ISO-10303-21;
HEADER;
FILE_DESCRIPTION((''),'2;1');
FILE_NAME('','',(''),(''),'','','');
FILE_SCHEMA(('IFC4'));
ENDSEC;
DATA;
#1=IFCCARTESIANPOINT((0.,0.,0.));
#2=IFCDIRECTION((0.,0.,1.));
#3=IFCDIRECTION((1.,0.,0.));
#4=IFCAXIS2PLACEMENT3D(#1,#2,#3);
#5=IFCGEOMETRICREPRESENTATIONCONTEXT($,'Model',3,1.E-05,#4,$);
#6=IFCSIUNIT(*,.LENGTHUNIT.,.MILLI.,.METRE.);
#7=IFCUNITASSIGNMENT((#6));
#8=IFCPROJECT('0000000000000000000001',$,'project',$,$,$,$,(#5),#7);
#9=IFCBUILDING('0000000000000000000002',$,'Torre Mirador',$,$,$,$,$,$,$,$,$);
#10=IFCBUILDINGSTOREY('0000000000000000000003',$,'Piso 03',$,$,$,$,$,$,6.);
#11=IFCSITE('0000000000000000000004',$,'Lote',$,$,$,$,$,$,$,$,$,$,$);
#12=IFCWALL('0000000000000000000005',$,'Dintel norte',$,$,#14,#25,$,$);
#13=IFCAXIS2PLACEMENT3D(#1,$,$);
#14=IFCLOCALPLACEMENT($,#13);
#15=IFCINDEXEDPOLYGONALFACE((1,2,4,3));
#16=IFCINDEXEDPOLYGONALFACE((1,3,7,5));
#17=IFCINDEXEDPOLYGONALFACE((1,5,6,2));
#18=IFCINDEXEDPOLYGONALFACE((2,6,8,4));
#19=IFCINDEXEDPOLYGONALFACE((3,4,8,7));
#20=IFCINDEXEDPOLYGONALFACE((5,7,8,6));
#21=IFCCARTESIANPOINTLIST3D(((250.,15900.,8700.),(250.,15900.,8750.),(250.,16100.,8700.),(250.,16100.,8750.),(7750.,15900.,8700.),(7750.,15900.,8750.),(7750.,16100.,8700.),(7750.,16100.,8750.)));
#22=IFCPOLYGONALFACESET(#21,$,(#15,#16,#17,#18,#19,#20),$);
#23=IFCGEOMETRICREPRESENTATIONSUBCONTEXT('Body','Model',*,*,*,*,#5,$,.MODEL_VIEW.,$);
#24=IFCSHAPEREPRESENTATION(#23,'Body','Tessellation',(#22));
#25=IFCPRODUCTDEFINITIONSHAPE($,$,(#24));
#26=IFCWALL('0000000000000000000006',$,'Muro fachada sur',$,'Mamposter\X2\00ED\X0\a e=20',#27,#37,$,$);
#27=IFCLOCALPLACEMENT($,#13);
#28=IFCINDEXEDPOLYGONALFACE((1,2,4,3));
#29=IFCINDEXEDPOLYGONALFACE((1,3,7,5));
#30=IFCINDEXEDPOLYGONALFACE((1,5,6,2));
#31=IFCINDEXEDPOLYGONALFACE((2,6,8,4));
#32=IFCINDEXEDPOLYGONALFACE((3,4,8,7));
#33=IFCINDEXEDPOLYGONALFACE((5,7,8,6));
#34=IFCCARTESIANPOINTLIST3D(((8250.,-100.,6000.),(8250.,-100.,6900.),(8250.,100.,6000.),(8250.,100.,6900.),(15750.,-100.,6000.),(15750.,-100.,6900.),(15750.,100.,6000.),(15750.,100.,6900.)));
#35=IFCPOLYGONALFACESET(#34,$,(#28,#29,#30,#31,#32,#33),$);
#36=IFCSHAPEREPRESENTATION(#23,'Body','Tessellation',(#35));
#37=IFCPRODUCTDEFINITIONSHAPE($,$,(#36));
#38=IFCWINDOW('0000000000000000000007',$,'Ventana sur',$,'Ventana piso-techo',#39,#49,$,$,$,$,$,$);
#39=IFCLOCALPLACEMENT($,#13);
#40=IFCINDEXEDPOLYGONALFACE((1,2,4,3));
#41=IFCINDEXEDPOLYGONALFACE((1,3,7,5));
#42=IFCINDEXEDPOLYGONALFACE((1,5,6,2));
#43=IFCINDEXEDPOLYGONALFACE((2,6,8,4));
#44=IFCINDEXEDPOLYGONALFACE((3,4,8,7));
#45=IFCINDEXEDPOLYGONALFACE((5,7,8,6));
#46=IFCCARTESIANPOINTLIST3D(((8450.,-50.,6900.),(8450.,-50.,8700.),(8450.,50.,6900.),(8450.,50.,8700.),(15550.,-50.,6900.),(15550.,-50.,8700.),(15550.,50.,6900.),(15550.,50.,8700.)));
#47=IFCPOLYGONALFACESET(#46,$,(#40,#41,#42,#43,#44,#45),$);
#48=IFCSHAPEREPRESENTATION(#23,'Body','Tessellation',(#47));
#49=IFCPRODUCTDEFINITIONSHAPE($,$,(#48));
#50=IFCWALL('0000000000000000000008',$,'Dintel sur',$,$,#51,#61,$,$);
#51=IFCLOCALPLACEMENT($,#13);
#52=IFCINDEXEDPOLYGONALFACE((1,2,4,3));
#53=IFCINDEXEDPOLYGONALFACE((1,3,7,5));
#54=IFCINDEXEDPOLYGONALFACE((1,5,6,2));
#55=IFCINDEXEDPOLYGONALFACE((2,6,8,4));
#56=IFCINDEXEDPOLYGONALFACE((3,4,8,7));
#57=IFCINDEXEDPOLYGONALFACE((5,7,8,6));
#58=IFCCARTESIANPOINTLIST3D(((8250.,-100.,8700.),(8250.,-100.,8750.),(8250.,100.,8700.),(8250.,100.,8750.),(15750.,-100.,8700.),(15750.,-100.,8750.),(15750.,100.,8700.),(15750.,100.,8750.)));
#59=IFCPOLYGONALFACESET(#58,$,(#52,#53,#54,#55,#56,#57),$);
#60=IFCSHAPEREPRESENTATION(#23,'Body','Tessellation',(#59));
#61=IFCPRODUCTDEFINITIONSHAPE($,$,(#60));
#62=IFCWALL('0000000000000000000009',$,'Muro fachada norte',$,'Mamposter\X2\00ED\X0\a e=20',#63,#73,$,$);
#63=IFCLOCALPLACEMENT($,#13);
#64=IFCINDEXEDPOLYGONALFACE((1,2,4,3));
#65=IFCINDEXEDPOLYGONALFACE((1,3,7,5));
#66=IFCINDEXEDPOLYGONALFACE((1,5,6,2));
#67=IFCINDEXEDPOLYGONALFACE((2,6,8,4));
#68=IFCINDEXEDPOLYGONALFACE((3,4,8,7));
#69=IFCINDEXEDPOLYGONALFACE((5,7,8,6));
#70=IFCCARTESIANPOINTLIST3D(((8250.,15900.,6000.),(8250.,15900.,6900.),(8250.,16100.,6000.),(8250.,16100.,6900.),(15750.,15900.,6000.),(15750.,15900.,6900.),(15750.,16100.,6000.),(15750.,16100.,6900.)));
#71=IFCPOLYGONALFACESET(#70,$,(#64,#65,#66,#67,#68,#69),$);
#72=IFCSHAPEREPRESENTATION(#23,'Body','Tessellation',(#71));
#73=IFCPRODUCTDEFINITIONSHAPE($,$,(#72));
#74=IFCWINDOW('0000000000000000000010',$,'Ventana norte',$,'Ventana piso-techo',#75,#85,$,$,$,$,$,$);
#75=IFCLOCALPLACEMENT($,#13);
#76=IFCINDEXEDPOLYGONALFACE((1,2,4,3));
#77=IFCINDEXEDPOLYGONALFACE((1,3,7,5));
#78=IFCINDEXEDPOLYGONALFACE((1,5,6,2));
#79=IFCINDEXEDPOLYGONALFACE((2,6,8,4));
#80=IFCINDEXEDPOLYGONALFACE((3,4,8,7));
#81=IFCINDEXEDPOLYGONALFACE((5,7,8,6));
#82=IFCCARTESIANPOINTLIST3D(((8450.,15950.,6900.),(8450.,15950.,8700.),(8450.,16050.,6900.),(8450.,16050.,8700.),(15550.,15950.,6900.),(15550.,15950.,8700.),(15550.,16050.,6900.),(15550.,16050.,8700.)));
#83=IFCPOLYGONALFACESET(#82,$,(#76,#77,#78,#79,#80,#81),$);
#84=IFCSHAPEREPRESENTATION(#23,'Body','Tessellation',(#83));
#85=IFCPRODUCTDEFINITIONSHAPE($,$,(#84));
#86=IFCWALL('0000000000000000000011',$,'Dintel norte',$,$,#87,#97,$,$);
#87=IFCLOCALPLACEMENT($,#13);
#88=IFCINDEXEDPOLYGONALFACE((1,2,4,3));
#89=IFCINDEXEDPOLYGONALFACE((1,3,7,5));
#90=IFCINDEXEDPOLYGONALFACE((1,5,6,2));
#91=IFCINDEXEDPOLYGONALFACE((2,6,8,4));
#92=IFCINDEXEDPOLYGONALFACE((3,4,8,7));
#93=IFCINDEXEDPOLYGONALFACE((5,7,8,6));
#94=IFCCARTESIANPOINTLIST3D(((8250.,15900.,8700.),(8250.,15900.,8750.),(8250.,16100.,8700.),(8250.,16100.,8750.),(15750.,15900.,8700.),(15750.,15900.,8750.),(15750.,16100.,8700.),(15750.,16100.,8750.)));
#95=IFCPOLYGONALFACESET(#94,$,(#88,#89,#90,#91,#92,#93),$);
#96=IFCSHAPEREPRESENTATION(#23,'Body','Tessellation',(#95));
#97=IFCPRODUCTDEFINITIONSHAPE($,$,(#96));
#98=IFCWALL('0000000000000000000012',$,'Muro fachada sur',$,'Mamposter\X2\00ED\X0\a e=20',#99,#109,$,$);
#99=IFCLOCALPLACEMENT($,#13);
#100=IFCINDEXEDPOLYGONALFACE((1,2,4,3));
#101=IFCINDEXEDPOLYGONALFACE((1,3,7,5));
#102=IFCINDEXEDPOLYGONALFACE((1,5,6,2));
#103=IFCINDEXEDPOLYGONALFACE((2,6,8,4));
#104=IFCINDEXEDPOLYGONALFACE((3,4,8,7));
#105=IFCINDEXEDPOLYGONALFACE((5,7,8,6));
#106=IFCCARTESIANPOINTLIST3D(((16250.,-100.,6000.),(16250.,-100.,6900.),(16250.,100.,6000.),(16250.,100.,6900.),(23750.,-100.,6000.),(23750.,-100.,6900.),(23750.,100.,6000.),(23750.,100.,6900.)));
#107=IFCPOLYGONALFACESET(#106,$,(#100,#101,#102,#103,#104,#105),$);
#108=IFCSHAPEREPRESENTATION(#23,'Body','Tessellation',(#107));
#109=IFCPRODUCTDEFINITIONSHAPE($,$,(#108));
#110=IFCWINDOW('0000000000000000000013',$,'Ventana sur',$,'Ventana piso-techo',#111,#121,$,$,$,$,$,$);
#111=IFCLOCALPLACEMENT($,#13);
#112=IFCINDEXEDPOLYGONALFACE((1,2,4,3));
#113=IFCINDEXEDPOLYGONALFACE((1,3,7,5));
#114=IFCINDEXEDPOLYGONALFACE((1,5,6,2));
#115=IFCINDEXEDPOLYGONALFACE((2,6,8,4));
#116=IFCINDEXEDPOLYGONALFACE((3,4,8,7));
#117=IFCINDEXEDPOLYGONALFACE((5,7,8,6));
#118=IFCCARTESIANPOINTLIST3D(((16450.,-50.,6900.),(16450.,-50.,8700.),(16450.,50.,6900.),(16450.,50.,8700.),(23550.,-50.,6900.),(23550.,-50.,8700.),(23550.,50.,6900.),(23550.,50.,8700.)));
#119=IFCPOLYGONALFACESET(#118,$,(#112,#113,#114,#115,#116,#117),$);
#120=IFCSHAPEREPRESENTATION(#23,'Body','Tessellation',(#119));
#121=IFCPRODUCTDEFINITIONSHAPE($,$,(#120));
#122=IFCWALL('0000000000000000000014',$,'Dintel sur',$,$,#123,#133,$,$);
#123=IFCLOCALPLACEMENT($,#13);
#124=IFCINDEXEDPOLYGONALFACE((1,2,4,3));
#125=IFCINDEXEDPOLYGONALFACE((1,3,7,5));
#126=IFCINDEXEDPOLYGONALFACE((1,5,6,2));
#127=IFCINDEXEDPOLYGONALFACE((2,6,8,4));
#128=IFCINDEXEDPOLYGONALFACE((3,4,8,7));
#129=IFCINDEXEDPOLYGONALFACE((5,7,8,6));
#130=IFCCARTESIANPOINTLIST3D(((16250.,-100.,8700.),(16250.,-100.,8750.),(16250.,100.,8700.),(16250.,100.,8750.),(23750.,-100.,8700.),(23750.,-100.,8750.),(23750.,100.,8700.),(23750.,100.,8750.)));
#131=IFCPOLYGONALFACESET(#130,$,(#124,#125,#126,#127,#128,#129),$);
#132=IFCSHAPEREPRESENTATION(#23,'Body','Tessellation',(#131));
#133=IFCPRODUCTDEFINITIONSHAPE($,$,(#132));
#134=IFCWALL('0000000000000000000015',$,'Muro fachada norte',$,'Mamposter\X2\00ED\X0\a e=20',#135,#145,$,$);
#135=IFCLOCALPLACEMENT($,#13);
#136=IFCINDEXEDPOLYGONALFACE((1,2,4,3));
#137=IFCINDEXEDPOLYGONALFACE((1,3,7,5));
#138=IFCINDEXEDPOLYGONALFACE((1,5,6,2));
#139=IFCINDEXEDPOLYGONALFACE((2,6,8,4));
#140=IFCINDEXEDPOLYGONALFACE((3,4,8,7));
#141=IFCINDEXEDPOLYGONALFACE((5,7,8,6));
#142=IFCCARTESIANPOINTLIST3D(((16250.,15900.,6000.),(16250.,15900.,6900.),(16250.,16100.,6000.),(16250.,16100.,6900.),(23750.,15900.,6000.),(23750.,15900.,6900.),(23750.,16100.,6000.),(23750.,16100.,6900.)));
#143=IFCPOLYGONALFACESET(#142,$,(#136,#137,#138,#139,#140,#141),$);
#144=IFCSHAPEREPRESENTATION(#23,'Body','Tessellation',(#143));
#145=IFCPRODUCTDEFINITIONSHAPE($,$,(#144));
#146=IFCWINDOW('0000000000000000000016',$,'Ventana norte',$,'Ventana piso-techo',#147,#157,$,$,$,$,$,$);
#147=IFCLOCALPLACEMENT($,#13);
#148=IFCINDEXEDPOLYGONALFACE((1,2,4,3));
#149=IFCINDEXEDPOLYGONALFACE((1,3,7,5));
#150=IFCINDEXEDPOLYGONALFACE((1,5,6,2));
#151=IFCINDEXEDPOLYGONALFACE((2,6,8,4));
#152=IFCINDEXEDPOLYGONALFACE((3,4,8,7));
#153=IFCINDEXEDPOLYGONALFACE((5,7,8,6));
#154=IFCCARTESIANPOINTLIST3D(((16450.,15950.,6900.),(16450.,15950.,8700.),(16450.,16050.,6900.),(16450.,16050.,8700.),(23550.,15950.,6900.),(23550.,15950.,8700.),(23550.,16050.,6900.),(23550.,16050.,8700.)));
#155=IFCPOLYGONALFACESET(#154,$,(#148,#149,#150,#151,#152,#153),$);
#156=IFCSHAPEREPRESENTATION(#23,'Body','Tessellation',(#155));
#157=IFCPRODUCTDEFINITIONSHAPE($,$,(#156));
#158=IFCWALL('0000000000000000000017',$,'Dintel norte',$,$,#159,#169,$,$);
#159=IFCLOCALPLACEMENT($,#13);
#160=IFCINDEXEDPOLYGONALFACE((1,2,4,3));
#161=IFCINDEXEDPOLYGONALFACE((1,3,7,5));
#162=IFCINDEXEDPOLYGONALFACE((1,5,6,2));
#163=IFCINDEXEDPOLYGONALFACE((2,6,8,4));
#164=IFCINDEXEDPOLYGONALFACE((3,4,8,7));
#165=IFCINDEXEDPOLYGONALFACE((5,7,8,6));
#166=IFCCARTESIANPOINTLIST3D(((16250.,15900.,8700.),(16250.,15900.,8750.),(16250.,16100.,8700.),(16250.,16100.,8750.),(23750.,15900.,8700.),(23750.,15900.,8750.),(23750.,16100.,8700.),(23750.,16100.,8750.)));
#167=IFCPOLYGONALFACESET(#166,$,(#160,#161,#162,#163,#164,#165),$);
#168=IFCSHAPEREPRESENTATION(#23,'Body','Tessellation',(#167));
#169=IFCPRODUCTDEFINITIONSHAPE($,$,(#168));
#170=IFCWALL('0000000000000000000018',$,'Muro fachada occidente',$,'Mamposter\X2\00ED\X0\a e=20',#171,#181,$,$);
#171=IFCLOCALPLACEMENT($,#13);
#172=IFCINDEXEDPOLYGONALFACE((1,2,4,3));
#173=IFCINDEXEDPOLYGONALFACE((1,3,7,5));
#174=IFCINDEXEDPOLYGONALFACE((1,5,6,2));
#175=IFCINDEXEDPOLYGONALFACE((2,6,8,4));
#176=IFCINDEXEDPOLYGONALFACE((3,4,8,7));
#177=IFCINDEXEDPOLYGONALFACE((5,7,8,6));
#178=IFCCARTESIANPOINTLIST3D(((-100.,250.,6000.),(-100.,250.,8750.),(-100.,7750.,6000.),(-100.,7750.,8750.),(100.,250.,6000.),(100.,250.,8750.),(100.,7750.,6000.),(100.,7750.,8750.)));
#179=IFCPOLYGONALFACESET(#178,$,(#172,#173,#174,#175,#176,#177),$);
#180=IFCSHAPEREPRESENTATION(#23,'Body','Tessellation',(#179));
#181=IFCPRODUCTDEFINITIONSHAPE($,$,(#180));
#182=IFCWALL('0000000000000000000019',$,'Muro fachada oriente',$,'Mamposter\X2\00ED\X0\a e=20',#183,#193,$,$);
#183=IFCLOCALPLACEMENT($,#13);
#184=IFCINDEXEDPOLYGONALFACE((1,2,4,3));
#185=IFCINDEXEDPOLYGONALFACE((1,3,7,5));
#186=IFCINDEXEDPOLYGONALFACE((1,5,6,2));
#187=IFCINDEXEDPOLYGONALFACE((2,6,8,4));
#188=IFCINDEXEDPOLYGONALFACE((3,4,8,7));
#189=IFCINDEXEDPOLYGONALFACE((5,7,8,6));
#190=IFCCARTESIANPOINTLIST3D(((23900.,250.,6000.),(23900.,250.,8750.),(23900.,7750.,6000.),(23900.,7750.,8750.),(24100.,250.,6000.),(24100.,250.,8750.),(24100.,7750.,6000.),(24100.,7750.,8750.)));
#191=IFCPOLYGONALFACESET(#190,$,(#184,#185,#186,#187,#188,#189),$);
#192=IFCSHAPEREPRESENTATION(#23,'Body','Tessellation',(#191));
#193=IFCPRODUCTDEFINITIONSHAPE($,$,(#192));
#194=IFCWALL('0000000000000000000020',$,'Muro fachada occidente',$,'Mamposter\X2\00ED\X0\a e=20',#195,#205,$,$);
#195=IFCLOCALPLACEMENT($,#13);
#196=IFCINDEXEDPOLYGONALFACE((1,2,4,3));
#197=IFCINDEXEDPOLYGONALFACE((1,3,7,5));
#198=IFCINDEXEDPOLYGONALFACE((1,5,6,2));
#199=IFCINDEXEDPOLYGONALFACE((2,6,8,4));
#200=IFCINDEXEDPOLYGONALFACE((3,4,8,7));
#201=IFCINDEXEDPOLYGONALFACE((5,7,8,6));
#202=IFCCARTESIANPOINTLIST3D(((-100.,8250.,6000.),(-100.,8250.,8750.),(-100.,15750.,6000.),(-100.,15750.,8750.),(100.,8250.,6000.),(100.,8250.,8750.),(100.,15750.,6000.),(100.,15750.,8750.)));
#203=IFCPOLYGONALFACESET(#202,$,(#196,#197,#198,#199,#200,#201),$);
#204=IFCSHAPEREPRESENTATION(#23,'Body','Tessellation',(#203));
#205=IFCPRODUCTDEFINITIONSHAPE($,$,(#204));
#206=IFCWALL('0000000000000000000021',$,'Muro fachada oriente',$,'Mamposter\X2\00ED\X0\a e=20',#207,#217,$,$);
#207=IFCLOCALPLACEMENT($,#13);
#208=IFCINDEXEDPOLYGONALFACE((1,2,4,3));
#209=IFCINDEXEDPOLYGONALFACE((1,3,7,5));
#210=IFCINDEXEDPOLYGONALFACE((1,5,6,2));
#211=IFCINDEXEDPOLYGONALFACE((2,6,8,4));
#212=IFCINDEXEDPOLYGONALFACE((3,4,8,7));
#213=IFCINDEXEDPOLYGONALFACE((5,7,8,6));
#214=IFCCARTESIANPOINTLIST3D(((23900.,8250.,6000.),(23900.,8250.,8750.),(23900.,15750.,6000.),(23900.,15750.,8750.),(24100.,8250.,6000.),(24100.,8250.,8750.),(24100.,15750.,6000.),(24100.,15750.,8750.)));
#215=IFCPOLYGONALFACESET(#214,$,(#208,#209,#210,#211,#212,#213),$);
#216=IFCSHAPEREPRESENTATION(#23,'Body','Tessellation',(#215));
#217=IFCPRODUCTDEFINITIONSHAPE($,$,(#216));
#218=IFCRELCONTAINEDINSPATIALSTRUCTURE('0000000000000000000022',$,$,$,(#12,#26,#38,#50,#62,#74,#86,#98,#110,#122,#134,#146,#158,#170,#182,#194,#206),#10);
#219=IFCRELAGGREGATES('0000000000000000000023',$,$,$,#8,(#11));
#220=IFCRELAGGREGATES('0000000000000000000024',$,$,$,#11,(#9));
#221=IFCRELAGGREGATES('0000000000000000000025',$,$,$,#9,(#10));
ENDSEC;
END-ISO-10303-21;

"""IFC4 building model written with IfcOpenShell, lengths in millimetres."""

from ifc_helpers import new_model, si_unit, frame, origin_with_axes, place, context, subcontext, project, spatial, indexed_curve, outline, extrude, element, save


model = new_model("IFC4")

# Units and contexts
model_context = context("Model", 3, precision=1e-05, world=origin_with_axes())
body_context = subcontext(model_context, "Body", "Model", "MODEL_VIEW")
ifc_project = project(units=[si_unit("LENGTHUNIT", "METRE", prefix="MILLI")], contexts=[model_context])

# Site, building, storey
site = spatial("IfcSite", under=ifc_project, Name="Lote")
building = spatial("IfcBuilding", under=site, Name="Torre Mirador")
storey = spatial("IfcBuildingStorey", under=building, Name="Piso 03", Elevation=6.0)

# Walls
wall_1_placement = place(None, frame((250.0, 15900.0, 8700.0), z_axis=(0.0, 0.0, 1.0), x_axis=(1.0, 0.0, 0.0)))
element("IfcWall", 1, at=wall_1_placement, inside=storey, Name="Dintel norte", context=body_context, shape_type="SweptSolid", body=[
    extrude(outline(indexed_curve([(0.0, 0.0), (0.0, 200.0), (7500.0, 200.0), (7500.0, 0.0), (0.0, 0.0)], self_intersect=False)), origin_with_axes(), (0.0, 0.0, 1.0), 50.0),
])
wall_2_placement = place(None, frame((8250.0, -100.0, 6000.0), z_axis=(0.0, 0.0, 1.0), x_axis=(1.0, 0.0, 0.0)))
element("IfcWall", 2, at=wall_2_placement, inside=storey, Name="Muro fachada sur", ObjectType="Mampostería e=20", context=body_context, shape_type="SweptSolid", body=[
    extrude(outline(indexed_curve([(0.0, 0.0), (0.0, 200.0), (7500.0, 200.0), (7500.0, 0.0), (0.0, 0.0)], self_intersect=False)), origin_with_axes(), (0.0, 0.0, 1.0), 900.0),
])

# Window
window_1_placement = place(None, frame((8450.0, -50.0, 6900.0), z_axis=(0.0, 0.0, 1.0), x_axis=(1.0, 0.0, 0.0)))
element("IfcWindow", 3, at=window_1_placement, inside=storey, Name="Ventana sur", ObjectType="Ventana piso-techo", context=body_context, shape_type="SweptSolid", body=[
    extrude(outline(indexed_curve([(0.0, 0.0), (0.0, 100.0), (7100.0, 100.0), (7100.0, 0.0), (0.0, 0.0)], self_intersect=False)), origin_with_axes(), (0.0, 0.0, 1.0), 1800.0),
])

# Walls
wall_3_placement = place(None, frame((8250.0, -100.0, 8700.0), z_axis=(0.0, 0.0, 1.0), x_axis=(1.0, 0.0, 0.0)))
element("IfcWall", 4, at=wall_3_placement, inside=storey, Name="Dintel sur", context=body_context, shape_type="SweptSolid", body=[
    extrude(outline(indexed_curve([(0.0, 0.0), (0.0, 200.0), (7500.0, 200.0), (7500.0, 0.0), (0.0, 0.0)], self_intersect=False)), origin_with_axes(), (0.0, 0.0, 1.0), 50.0),
])
wall_4_placement = place(None, frame((8250.0, 15900.0, 6000.0), z_axis=(0.0, 0.0, 1.0), x_axis=(1.0, 0.0, 0.0)))
element("IfcWall", 5, at=wall_4_placement, inside=storey, Name="Muro fachada norte", ObjectType="Mampostería e=20", context=body_context, shape_type="SweptSolid", body=[
    extrude(outline(indexed_curve([(0.0, 0.0), (0.0, 200.0), (7500.0, 200.0), (7500.0, 0.0), (0.0, 0.0)], self_intersect=False)), origin_with_axes(), (0.0, 0.0, 1.0), 900.0),
])

# Window
window_2_placement = place(None, frame((8450.0, 15950.0, 6900.0), z_axis=(0.0, 0.0, 1.0), x_axis=(1.0, 0.0, 0.0)))
element("IfcWindow", 6, at=window_2_placement, inside=storey, Name="Ventana norte", ObjectType="Ventana piso-techo", context=body_context, shape_type="SweptSolid", body=[
    extrude(outline(indexed_curve([(0.0, 0.0), (0.0, 100.0), (7100.0, 100.0), (7100.0, 0.0), (0.0, 0.0)], self_intersect=False)), origin_with_axes(), (0.0, 0.0, 1.0), 1800.0),
])

# Walls
wall_5_placement = place(None, frame((8250.0, 15900.0, 8700.0), z_axis=(0.0, 0.0, 1.0), x_axis=(1.0, 0.0, 0.0)))
element("IfcWall", 7, at=wall_5_placement, inside=storey, Name="Dintel norte", context=body_context, shape_type="SweptSolid", body=[
    extrude(outline(indexed_curve([(0.0, 0.0), (0.0, 200.0), (7500.0, 200.0), (7500.0, 0.0), (0.0, 0.0)], self_intersect=False)), origin_with_axes(), (0.0, 0.0, 1.0), 50.0),
])
wall_6_placement = place(None, frame((16250.0, -100.0, 6000.0), z_axis=(0.0, 0.0, 1.0), x_axis=(1.0, 0.0, 0.0)))
element("IfcWall", 8, at=wall_6_placement, inside=storey, Name="Muro fachada sur", ObjectType="Mampostería e=20", context=body_context, shape_type="SweptSolid", body=[
    extrude(outline(indexed_curve([(0.0, 0.0), (0.0, 200.0), (7500.0, 200.0), (7500.0, 0.0), (0.0, 0.0)], self_intersect=False)), origin_with_axes(), (0.0, 0.0, 1.0), 900.0),
])

# Window
window_3_placement = place(None, frame((16450.0, -50.0, 6900.0), z_axis=(0.0, 0.0, 1.0), x_axis=(1.0, 0.0, 0.0)))
element("IfcWindow", 9, at=window_3_placement, inside=storey, Name="Ventana sur", ObjectType="Ventana piso-techo", context=body_context, shape_type="SweptSolid", body=[
    extrude(outline(indexed_curve([(0.0, 0.0), (0.0, 100.0), (7100.0, 100.0), (7100.0, 0.0), (0.0, 0.0)], self_intersect=False)), origin_with_axes(), (0.0, 0.0, 1.0), 1800.0),
])

# Walls
wall_7_placement = place(None, frame((16250.0, -100.0, 8700.0), z_axis=(0.0, 0.0, 1.0), x_axis=(1.0, 0.0, 0.0)))
element("IfcWall", 10, at=wall_7_placement, inside=storey, Name="Dintel sur", context=body_context, shape_type="SweptSolid", body=[
    extrude(outline(indexed_curve([(0.0, 0.0), (0.0, 200.0), (7500.0, 200.0), (7500.0, 0.0), (0.0, 0.0)], self_intersect=False)), origin_with_axes(), (0.0, 0.0, 1.0), 50.0),
])
wall_8_placement = place(None, frame((16250.0, 15900.0, 6000.0), z_axis=(0.0, 0.0, 1.0), x_axis=(1.0, 0.0, 0.0)))
element("IfcWall", 11, at=wall_8_placement, inside=storey, Name="Muro fachada norte", ObjectType="Mampostería e=20", context=body_context, shape_type="SweptSolid", body=[
    extrude(outline(indexed_curve([(0.0, 0.0), (0.0, 200.0), (7500.0, 200.0), (7500.0, 0.0), (0.0, 0.0)], self_intersect=False)), origin_with_axes(), (0.0, 0.0, 1.0), 900.0),
])

# Window
window_4_placement = place(None, frame((16450.0, 15950.0, 6900.0), z_axis=(0.0, 0.0, 1.0), x_axis=(1.0, 0.0, 0.0)))
element("IfcWindow", 12, at=window_4_placement, inside=storey, Name="Ventana norte", ObjectType="Ventana piso-techo", context=body_context, shape_type="SweptSolid", body=[
    extrude(outline(indexed_curve([(0.0, 0.0), (0.0, 100.0), (7100.0, 100.0), (7100.0, 0.0), (0.0, 0.0)], self_intersect=False)), origin_with_axes(), (0.0, 0.0, 1.0), 1800.0),
])

# Walls
wall_9_placement = place(None, frame((16250.0, 15900.0, 8700.0), z_axis=(0.0, 0.0, 1.0), x_axis=(1.0, 0.0, 0.0)))
element("IfcWall", 13, at=wall_9_placement, inside=storey, Name="Dintel norte", context=body_context, shape_type="SweptSolid", body=[
    extrude(outline(indexed_curve([(0.0, 0.0), (0.0, 200.0), (7500.0, 200.0), (7500.0, 0.0), (0.0, 0.0)], self_intersect=False)), origin_with_axes(), (0.0, 0.0, 1.0), 50.0),
])
for number, where, z_axis, x_axis, name in (
    (14, (-100.0, 250.0, 6000.0), (0.0, 0.0, 1.0), (1.0, 0.0, 0.0), "Muro fachada occidente"),
    (15, (23900.0, 250.0, 6000.0), (0.0, 0.0, 1.0), (1.0, 0.0, 0.0), "Muro fachada oriente"),
    (16, (-100.0, 8250.0, 6000.0), (0.0, 0.0, 1.0), (1.0, 0.0, 0.0), "Muro fachada occidente"),
    (17, (23900.0, 8250.0, 6000.0), (0.0, 0.0, 1.0), (1.0, 0.0, 0.0), "Muro fachada oriente"),
):
    element("IfcWall", number, at=place(None, frame(where, z_axis=z_axis, x_axis=x_axis)), inside=storey, Name=name, ObjectType="Mampostería e=20", context=body_context, shape_type="SweptSolid", body=[
        extrude(outline(indexed_curve([(0.0, 0.0), (0.0, 7500.0), (200.0, 7500.0), (200.0, 0.0), (0.0, 0.0)], self_intersect=False)), origin_with_axes(), (0.0, 0.0, 1.0), 2750.0),
    ])

save(model, "model.ifc")
